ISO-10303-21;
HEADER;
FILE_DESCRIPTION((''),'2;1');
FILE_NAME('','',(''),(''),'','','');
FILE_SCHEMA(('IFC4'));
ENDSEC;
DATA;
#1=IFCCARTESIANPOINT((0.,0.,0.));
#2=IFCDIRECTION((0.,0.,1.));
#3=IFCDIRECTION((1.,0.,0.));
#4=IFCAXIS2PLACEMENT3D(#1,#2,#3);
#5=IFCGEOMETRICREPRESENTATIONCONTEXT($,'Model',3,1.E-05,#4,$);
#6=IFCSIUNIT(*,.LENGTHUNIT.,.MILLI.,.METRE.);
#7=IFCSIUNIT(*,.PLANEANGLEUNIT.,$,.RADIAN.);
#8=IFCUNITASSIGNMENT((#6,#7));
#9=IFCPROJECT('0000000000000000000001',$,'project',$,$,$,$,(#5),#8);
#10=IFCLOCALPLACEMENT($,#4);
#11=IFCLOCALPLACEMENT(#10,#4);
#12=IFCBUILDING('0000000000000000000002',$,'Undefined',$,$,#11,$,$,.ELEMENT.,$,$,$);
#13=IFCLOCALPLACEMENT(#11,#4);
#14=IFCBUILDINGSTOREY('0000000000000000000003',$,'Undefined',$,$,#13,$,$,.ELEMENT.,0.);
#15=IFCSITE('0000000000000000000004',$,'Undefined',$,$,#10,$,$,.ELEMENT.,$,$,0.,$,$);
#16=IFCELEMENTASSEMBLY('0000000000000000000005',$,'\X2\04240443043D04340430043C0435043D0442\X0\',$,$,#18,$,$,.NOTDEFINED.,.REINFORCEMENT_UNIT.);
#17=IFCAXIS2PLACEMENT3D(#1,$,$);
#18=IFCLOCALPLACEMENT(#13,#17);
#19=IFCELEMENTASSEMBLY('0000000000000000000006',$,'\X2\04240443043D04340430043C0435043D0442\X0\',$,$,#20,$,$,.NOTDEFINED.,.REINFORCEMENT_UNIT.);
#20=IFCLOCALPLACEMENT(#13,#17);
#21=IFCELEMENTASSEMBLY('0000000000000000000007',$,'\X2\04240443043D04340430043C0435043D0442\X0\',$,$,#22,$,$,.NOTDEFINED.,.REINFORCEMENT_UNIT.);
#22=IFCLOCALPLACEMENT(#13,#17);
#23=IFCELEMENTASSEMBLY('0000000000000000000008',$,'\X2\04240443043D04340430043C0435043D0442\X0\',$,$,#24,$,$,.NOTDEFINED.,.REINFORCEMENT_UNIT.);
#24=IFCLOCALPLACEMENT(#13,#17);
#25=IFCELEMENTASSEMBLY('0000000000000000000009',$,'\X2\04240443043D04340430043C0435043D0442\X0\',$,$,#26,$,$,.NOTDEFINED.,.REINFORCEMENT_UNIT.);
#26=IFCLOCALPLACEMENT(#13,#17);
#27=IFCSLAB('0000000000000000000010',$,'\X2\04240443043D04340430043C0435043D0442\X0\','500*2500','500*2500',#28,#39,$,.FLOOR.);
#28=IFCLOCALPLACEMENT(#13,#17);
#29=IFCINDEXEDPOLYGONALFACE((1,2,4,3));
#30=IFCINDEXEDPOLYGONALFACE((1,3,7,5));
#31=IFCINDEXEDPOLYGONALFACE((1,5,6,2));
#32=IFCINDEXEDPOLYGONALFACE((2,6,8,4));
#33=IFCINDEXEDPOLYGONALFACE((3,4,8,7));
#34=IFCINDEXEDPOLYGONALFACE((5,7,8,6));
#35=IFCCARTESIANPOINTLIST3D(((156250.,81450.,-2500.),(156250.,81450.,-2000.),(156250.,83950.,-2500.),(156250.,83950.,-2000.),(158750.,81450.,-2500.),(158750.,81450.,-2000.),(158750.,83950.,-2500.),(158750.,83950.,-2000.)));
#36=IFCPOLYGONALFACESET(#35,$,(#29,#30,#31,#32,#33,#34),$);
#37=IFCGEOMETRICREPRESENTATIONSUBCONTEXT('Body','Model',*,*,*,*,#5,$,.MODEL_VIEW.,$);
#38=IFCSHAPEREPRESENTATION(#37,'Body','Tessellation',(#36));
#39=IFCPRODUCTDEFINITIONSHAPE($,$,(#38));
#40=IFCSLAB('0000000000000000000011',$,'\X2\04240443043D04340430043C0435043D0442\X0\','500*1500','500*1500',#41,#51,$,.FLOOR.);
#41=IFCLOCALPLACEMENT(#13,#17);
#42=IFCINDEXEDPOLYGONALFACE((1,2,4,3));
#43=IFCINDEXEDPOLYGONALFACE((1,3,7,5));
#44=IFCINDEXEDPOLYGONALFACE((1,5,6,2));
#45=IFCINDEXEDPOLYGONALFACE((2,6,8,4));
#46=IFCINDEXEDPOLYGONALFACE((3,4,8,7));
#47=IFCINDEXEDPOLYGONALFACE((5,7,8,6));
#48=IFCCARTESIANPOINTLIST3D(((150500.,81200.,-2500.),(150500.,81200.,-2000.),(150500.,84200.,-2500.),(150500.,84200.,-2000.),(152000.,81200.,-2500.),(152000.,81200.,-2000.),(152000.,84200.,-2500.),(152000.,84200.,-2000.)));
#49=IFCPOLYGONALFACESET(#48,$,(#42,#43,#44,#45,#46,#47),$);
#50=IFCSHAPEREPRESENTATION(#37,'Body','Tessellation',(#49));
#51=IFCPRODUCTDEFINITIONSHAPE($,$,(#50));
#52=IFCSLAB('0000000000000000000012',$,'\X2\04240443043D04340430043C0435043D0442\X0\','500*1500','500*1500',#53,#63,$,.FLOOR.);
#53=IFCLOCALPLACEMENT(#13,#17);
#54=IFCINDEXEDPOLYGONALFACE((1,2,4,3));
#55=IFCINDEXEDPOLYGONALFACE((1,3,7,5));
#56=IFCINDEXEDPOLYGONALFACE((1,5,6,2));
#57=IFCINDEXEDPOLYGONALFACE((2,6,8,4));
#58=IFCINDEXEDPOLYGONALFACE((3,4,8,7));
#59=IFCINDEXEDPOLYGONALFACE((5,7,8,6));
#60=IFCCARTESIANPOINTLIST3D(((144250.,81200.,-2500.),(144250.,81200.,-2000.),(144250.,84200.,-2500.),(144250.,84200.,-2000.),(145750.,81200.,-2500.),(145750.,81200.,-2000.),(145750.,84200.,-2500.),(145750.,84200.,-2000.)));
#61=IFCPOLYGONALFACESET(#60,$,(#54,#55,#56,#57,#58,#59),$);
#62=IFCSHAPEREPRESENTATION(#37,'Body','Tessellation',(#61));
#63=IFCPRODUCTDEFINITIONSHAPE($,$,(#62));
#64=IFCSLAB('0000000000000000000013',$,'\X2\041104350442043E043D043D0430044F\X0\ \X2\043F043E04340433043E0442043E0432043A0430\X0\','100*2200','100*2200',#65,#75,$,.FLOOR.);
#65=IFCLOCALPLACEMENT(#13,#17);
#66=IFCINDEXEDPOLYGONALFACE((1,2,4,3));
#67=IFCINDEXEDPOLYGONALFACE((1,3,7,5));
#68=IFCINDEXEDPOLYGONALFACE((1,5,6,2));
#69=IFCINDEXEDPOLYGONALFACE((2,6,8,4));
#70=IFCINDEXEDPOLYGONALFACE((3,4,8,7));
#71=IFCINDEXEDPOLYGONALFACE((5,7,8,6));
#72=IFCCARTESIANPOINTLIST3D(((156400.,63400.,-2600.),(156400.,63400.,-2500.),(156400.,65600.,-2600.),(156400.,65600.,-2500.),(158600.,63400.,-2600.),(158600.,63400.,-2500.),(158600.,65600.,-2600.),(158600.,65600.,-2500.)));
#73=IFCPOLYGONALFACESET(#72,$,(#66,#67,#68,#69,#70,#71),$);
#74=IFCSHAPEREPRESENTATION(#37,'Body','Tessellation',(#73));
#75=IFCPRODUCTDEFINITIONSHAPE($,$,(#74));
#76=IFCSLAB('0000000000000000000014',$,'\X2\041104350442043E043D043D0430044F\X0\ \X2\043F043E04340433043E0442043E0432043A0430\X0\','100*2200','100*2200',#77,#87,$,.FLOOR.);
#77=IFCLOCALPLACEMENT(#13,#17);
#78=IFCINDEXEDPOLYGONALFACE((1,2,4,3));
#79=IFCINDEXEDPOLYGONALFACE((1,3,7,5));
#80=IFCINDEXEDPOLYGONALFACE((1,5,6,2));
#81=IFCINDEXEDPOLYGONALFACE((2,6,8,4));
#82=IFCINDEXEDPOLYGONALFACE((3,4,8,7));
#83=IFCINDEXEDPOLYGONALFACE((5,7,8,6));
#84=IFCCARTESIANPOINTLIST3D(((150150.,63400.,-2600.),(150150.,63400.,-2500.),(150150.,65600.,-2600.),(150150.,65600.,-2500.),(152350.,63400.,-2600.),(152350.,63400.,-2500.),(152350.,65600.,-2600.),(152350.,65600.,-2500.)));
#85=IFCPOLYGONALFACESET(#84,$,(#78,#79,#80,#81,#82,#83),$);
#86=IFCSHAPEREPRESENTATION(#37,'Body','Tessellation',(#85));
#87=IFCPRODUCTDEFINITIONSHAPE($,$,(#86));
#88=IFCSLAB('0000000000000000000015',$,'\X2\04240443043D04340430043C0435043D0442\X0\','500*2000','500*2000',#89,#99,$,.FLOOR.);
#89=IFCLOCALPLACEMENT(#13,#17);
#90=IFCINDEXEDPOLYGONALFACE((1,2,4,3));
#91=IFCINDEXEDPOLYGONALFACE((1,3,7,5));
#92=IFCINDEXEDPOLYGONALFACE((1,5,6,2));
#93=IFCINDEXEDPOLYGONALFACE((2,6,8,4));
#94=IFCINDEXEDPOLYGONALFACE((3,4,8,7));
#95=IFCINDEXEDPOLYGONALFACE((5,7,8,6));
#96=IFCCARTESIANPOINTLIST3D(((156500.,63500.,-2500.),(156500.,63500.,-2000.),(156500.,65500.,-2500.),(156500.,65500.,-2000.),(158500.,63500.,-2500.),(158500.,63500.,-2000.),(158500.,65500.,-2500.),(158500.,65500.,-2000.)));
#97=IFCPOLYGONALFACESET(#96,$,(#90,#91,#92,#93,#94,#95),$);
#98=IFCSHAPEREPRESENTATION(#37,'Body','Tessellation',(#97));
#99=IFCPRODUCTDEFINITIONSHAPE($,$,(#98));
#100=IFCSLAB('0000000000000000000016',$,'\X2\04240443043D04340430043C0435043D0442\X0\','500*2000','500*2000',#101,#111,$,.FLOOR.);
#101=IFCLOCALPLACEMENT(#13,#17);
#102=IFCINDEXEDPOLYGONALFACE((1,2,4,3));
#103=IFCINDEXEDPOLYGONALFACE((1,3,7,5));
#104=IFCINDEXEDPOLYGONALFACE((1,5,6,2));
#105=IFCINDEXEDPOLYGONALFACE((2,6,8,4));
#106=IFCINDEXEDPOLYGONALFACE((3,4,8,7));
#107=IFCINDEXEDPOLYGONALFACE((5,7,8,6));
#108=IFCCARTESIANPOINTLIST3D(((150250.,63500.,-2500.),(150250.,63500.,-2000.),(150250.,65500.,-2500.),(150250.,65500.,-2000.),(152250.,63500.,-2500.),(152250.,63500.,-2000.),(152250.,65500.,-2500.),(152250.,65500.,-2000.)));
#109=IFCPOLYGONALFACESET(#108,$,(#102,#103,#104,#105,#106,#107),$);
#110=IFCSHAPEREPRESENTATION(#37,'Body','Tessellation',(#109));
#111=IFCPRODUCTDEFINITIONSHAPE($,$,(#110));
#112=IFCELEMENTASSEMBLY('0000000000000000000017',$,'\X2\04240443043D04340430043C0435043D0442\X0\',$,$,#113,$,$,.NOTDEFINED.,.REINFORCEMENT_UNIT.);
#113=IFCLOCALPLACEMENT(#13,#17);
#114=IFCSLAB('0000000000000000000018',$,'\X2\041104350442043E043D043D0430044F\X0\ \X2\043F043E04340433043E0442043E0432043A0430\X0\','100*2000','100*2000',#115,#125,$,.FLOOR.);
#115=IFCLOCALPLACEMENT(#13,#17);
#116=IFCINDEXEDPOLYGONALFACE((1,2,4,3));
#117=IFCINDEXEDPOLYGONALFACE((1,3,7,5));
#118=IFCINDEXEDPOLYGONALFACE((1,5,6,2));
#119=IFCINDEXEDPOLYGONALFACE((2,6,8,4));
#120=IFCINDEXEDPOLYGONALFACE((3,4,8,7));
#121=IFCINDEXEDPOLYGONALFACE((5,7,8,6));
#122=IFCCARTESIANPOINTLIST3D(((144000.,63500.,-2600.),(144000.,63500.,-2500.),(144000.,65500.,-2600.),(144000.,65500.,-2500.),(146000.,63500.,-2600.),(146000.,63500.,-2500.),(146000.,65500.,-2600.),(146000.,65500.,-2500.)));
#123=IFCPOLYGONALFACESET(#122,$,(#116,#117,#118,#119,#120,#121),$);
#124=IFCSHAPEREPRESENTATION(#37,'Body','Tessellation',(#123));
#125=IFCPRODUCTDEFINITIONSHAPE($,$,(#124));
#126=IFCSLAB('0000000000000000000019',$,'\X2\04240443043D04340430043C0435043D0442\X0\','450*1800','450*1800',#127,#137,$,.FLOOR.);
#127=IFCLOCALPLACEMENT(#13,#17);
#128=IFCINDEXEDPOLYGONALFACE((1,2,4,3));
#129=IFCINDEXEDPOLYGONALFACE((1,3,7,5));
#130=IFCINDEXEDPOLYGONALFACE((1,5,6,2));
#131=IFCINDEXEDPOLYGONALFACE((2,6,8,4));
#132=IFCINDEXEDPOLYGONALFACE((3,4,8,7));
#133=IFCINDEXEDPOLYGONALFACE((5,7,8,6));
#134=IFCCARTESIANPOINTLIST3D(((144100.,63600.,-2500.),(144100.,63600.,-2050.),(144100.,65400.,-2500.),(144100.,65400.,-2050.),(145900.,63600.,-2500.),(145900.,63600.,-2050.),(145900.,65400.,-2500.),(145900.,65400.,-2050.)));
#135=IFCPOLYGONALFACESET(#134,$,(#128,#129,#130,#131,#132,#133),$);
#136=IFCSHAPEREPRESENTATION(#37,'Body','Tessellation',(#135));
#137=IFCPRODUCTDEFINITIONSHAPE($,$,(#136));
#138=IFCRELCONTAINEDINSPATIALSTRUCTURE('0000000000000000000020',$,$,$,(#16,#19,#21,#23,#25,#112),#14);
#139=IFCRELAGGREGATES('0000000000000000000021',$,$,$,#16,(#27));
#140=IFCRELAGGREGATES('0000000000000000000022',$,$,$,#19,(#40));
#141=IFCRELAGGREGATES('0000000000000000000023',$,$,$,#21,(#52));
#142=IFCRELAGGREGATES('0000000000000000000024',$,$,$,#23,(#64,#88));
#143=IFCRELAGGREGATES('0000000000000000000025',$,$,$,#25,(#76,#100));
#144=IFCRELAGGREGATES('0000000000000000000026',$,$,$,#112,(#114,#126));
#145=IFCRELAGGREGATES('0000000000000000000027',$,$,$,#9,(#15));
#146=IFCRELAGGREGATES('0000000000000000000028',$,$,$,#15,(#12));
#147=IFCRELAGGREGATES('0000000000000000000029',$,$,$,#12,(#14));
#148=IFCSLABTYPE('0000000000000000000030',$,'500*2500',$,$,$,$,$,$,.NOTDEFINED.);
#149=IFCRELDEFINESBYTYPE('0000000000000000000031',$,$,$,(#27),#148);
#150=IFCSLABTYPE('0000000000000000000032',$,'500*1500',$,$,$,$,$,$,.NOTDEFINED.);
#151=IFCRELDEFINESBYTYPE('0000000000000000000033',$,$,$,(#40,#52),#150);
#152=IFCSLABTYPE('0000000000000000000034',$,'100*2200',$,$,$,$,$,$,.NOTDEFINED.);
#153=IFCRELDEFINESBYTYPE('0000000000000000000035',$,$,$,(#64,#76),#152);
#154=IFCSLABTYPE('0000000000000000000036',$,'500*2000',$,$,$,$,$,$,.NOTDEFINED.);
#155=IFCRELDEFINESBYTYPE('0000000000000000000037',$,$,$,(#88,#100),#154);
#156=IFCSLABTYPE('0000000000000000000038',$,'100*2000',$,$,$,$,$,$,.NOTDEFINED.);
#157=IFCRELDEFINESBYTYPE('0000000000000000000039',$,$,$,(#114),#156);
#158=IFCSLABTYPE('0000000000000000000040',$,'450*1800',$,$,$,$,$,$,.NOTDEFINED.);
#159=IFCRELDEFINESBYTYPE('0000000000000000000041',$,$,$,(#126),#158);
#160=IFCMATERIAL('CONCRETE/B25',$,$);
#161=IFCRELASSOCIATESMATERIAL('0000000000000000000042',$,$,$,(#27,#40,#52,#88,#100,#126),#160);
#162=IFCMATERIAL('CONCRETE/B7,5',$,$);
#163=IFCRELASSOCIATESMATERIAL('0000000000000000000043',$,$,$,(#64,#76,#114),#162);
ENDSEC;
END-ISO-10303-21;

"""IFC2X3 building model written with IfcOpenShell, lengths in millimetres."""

from ifc_helpers import new_model, si_unit, frame, origin_with_axes, place, context, subcontext, project, spatial, polyline, outline, extrude, material, type_object, element, aggregate, save


model = new_model("IFC2X3")

# Units and contexts
model_context = context("Model", 3, precision=1e-05, world=origin_with_axes())
body_context = subcontext(model_context, "Body", "Model", "MODEL_VIEW")
ifc_project = project(units=[si_unit("LENGTHUNIT", "METRE", prefix="MILLI"), si_unit("PLANEANGLEUNIT", "RADIAN")], contexts=[model_context])

# Site, building, storey
site_placement = place(None, origin_with_axes())
site = spatial("IfcSite", under=ifc_project, at=site_placement, Name="Undefined", CompositionType="ELEMENT", RefElevation=0.0)
building_placement = place(site_placement, origin_with_axes())
building = spatial("IfcBuilding", under=site, at=building_placement, Name="Undefined", CompositionType="ELEMENT")
storey_placement = place(building_placement, origin_with_axes())
storey = spatial("IfcBuildingStorey", under=building, at=storey_placement, Name="Undefined", CompositionType="ELEMENT", Elevation=0.0)

# Element assemblies
assembly_1_placement = place(storey_placement, origin_with_axes())
assembly_1 = element("IfcElementAssembly", 1, at=assembly_1_placement, inside=storey, Name="Фундамент", AssemblyPlace="NOTDEFINED", PredefinedType="REINFORCEMENT_UNIT")
ifc_material_1 = material(Name="CONCRETE/B25")
assembly_2_placement = place(storey_placement, origin_with_axes())
assembly_2 = element("IfcElementAssembly", 2, at=assembly_2_placement, inside=storey, Name="Фундамент", AssemblyPlace="NOTDEFINED", PredefinedType="REINFORCEMENT_UNIT")
assembly_3_placement = place(storey_placement, origin_with_axes())
assembly_3 = element("IfcElementAssembly", 3, at=assembly_3_placement, inside=storey, Name="Фундамент", AssemblyPlace="NOTDEFINED", PredefinedType="REINFORCEMENT_UNIT")

# Shared definitions
ifc_material_2 = material(Name="CONCRETE/B7,5")

# Element assemblies
assembly_4_placement = place(storey_placement, origin_with_axes())
assembly_4 = element("IfcElementAssembly", 4, at=assembly_4_placement, inside=storey, Name="Фундамент", AssemblyPlace="NOTDEFINED", PredefinedType="REINFORCEMENT_UNIT")
assembly_5_placement = place(storey_placement, origin_with_axes())
assembly_5 = element("IfcElementAssembly", 5, at=assembly_5_placement, inside=storey, Name="Фундамент", AssemblyPlace="NOTDEFINED", PredefinedType="REINFORCEMENT_UNIT")

# Slabs
slab_type_1 = type_object("IfcSlabType", Name="500*2500", PredefinedType="NOTDEFINED")
slab_1_placement = place(assembly_1_placement, frame((156250.0, 83950.0, -2250.0), z_axis=(0.0, 0.0, 1.0), x_axis=(0.0, -1.0, 0.0)))
slab_1 = element("IfcSlab", 6, at=slab_1_placement, type_object=slab_type_1, material=ifc_material_1, Name="Фундамент", Description="500*2500", ObjectType="500*2500", PredefinedType="FLOOR", context=body_context, shape_type="SweptSolid", body=[
    extrude(outline(polyline([(0.0, 0.0), (2500.0, 0.0), (2500.0, 2500.0), (0.0, 2500.0), (0.0, 0.0)])), frame((0.0, 0.0, -250.0), z_axis=(0.0, 0.0, 1.0), x_axis=(1.0, 0.0, 0.0)), (0.0, 0.0, 1.0), 500.0),
])
aggregate(assembly_1, [slab_1])
slab_type_2 = type_object("IfcSlabType", Name="500*1500", PredefinedType="NOTDEFINED")
slab_2_placement = place(assembly_2_placement, frame((150500.0, 84200.0, -2250.0), z_axis=(0.0, 0.0, 1.0), x_axis=(0.0, -1.0, 0.0)))
slab_2 = element("IfcSlab", 7, at=slab_2_placement, type_object=slab_type_2, material=ifc_material_1, Name="Фундамент", Description="500*1500", ObjectType="500*1500", PredefinedType="FLOOR", context=body_context, shape_type="SweptSolid", body=[
    extrude(outline(polyline([(0.0, 0.0), (3000.0, 0.0), (3000.0, 1500.0), (0.0, 1500.0), (0.0, 0.0)])), frame((0.0, 0.0, -250.0), z_axis=(0.0, 0.0, 1.0), x_axis=(1.0, 0.0, 0.0)), (0.0, 0.0, 1.0), 500.0),
])
aggregate(assembly_2, [slab_2])
slab_3_placement = place(assembly_3_placement, frame((144250.0, 84200.0, -2250.0), z_axis=(0.0, 0.0, 1.0), x_axis=(0.0, -1.0, 0.0)))
slab_3 = element("IfcSlab", 8, at=slab_3_placement, type_object=slab_type_2, material=ifc_material_1, Name="Фундамент", Description="500*1500", ObjectType="500*1500", PredefinedType="FLOOR", context=body_context, shape_type="SweptSolid", body=[
    extrude(outline(polyline([(0.0, 0.0), (3000.0, 0.0), (3000.0, 1500.0), (0.0, 1500.0), (0.0, 0.0)])), frame((0.0, 0.0, -250.0), z_axis=(0.0, 0.0, 1.0), x_axis=(1.0, 0.0, 0.0)), (0.0, 0.0, 1.0), 500.0),
])
aggregate(assembly_3, [slab_3])
slab_type_3 = type_object("IfcSlabType", Name="100*2200", PredefinedType="NOTDEFINED")
slab_4_placement = place(assembly_4_placement, frame((156400.0, 65600.0, -2550.0), z_axis=(0.0, 0.0, 1.0), x_axis=(0.0, -1.0, 0.0)))
slab_4 = element("IfcSlab", 9, at=slab_4_placement, type_object=slab_type_3, material=ifc_material_2, Name="Бетонная подготовка", Description="100*2200", ObjectType="100*2200", PredefinedType="FLOOR", context=body_context, shape_type="SweptSolid", body=[
    extrude(outline(polyline([(0.0, 0.0), (2200.0, 0.0), (2200.0, 2200.0), (0.0, 2200.0), (0.0, 0.0)])), frame((0.0, 0.0, -50.0), z_axis=(0.0, 0.0, 1.0), x_axis=(1.0, 0.0, 0.0)), (0.0, 0.0, 1.0), 100.0),
])
slab_5_placement = place(assembly_5_placement, frame((150150.0, 65600.0, -2550.0), z_axis=(0.0, 0.0, 1.0), x_axis=(0.0, -1.0, 0.0)))
slab_5 = element("IfcSlab", 10, at=slab_5_placement, type_object=slab_type_3, material=ifc_material_2, Name="Бетонная подготовка", Description="100*2200", ObjectType="100*2200", PredefinedType="FLOOR", context=body_context, shape_type="SweptSolid", body=[
    extrude(outline(polyline([(0.0, 0.0), (2200.0, 0.0), (2200.0, 2200.0), (0.0, 2200.0), (0.0, 0.0)])), frame((0.0, 0.0, -50.0), z_axis=(0.0, 0.0, 1.0), x_axis=(1.0, 0.0, 0.0)), (0.0, 0.0, 1.0), 100.0),
])
slab_type_4 = type_object("IfcSlabType", Name="500*2000", PredefinedType="NOTDEFINED")
slab_6_placement = place(assembly_4_placement, frame((156500.0, 65500.0, -2250.0), z_axis=(0.0, 0.0, 1.0), x_axis=(0.0, -1.0, 0.0)))
slab_6 = element("IfcSlab", 11, at=slab_6_placement, type_object=slab_type_4, material=ifc_material_1, Name="Фундамент", Description="500*2000", ObjectType="500*2000", PredefinedType="FLOOR", context=body_context, shape_type="SweptSolid", body=[
    extrude(outline(polyline([(0.0, 0.0), (2000.0, 0.0), (2000.0, 2000.0), (0.0, 2000.0), (0.0, 0.0)])), frame((0.0, 0.0, -250.0), z_axis=(0.0, 0.0, 1.0), x_axis=(1.0, 0.0, 0.0)), (0.0, 0.0, 1.0), 500.0),
])
aggregate(assembly_4, [slab_4, slab_6])
slab_7_placement = place(assembly_5_placement, frame((150250.0, 65500.0, -2250.0), z_axis=(0.0, 0.0, 1.0), x_axis=(0.0, -1.0, 0.0)))
slab_7 = element("IfcSlab", 12, at=slab_7_placement, type_object=slab_type_4, material=ifc_material_1, Name="Фундамент", Description="500*2000", ObjectType="500*2000", PredefinedType="FLOOR", context=body_context, shape_type="SweptSolid", body=[
    extrude(outline(polyline([(0.0, 0.0), (2000.0, 0.0), (2000.0, 2000.0), (0.0, 2000.0), (0.0, 0.0)])), frame((0.0, 0.0, -250.0), z_axis=(0.0, 0.0, 1.0), x_axis=(1.0, 0.0, 0.0)), (0.0, 0.0, 1.0), 500.0),
])
aggregate(assembly_5, [slab_5, slab_7])

# Element assembly, slabs
assembly_6_placement = place(storey_placement, origin_with_axes())
assembly_6 = element("IfcElementAssembly", 13, at=assembly_6_placement, inside=storey, Name="Фундамент", AssemblyPlace="NOTDEFINED", PredefinedType="REINFORCEMENT_UNIT")
slab_type_5 = type_object("IfcSlabType", Name="100*2000", PredefinedType="NOTDEFINED")
slab_8_placement = place(assembly_6_placement, frame((144000.0, 65500.0, -2550.0), z_axis=(0.0, 0.0, 1.0), x_axis=(0.0, -1.0, 0.0)))
slab_8 = element("IfcSlab", 14, at=slab_8_placement, type_object=slab_type_5, material=ifc_material_2, Name="Бетонная подготовка", Description="100*2000", ObjectType="100*2000", PredefinedType="FLOOR", context=body_context, shape_type="SweptSolid", body=[
    extrude(outline(polyline([(0.0, 0.0), (2000.0, 0.0), (2000.0, 2000.0), (0.0, 2000.0), (0.0, 0.0)])), frame((0.0, 0.0, -50.0), z_axis=(0.0, 0.0, 1.0), x_axis=(1.0, 0.0, 0.0)), (0.0, 0.0, 1.0), 100.0),
])
slab_type_6 = type_object("IfcSlabType", Name="450*1800", PredefinedType="NOTDEFINED")
slab_9_placement = place(assembly_6_placement, frame((144100.0, 65400.0, -2275.0), z_axis=(0.0, 0.0, 1.0), x_axis=(0.0, -1.0, 0.0)))
slab_9 = element("IfcSlab", 15, at=slab_9_placement, type_object=slab_type_6, material=ifc_material_1, Name="Фундамент", Description="450*1800", ObjectType="450*1800", PredefinedType="FLOOR", context=body_context, shape_type="SweptSolid", body=[
    extrude(outline(polyline([(0.0, 0.0), (1800.0, 0.0), (1800.0, 1800.0), (0.0, 1800.0), (0.0, 0.0)])), frame((0.0, 0.0, -225.0), z_axis=(0.0, 0.0, 1.0), x_axis=(1.0, 0.0, 0.0)), (0.0, 0.0, 1.0), 450.0),
])
aggregate(assembly_6, [slab_8, slab_9])

save(model, "model.ifc")
